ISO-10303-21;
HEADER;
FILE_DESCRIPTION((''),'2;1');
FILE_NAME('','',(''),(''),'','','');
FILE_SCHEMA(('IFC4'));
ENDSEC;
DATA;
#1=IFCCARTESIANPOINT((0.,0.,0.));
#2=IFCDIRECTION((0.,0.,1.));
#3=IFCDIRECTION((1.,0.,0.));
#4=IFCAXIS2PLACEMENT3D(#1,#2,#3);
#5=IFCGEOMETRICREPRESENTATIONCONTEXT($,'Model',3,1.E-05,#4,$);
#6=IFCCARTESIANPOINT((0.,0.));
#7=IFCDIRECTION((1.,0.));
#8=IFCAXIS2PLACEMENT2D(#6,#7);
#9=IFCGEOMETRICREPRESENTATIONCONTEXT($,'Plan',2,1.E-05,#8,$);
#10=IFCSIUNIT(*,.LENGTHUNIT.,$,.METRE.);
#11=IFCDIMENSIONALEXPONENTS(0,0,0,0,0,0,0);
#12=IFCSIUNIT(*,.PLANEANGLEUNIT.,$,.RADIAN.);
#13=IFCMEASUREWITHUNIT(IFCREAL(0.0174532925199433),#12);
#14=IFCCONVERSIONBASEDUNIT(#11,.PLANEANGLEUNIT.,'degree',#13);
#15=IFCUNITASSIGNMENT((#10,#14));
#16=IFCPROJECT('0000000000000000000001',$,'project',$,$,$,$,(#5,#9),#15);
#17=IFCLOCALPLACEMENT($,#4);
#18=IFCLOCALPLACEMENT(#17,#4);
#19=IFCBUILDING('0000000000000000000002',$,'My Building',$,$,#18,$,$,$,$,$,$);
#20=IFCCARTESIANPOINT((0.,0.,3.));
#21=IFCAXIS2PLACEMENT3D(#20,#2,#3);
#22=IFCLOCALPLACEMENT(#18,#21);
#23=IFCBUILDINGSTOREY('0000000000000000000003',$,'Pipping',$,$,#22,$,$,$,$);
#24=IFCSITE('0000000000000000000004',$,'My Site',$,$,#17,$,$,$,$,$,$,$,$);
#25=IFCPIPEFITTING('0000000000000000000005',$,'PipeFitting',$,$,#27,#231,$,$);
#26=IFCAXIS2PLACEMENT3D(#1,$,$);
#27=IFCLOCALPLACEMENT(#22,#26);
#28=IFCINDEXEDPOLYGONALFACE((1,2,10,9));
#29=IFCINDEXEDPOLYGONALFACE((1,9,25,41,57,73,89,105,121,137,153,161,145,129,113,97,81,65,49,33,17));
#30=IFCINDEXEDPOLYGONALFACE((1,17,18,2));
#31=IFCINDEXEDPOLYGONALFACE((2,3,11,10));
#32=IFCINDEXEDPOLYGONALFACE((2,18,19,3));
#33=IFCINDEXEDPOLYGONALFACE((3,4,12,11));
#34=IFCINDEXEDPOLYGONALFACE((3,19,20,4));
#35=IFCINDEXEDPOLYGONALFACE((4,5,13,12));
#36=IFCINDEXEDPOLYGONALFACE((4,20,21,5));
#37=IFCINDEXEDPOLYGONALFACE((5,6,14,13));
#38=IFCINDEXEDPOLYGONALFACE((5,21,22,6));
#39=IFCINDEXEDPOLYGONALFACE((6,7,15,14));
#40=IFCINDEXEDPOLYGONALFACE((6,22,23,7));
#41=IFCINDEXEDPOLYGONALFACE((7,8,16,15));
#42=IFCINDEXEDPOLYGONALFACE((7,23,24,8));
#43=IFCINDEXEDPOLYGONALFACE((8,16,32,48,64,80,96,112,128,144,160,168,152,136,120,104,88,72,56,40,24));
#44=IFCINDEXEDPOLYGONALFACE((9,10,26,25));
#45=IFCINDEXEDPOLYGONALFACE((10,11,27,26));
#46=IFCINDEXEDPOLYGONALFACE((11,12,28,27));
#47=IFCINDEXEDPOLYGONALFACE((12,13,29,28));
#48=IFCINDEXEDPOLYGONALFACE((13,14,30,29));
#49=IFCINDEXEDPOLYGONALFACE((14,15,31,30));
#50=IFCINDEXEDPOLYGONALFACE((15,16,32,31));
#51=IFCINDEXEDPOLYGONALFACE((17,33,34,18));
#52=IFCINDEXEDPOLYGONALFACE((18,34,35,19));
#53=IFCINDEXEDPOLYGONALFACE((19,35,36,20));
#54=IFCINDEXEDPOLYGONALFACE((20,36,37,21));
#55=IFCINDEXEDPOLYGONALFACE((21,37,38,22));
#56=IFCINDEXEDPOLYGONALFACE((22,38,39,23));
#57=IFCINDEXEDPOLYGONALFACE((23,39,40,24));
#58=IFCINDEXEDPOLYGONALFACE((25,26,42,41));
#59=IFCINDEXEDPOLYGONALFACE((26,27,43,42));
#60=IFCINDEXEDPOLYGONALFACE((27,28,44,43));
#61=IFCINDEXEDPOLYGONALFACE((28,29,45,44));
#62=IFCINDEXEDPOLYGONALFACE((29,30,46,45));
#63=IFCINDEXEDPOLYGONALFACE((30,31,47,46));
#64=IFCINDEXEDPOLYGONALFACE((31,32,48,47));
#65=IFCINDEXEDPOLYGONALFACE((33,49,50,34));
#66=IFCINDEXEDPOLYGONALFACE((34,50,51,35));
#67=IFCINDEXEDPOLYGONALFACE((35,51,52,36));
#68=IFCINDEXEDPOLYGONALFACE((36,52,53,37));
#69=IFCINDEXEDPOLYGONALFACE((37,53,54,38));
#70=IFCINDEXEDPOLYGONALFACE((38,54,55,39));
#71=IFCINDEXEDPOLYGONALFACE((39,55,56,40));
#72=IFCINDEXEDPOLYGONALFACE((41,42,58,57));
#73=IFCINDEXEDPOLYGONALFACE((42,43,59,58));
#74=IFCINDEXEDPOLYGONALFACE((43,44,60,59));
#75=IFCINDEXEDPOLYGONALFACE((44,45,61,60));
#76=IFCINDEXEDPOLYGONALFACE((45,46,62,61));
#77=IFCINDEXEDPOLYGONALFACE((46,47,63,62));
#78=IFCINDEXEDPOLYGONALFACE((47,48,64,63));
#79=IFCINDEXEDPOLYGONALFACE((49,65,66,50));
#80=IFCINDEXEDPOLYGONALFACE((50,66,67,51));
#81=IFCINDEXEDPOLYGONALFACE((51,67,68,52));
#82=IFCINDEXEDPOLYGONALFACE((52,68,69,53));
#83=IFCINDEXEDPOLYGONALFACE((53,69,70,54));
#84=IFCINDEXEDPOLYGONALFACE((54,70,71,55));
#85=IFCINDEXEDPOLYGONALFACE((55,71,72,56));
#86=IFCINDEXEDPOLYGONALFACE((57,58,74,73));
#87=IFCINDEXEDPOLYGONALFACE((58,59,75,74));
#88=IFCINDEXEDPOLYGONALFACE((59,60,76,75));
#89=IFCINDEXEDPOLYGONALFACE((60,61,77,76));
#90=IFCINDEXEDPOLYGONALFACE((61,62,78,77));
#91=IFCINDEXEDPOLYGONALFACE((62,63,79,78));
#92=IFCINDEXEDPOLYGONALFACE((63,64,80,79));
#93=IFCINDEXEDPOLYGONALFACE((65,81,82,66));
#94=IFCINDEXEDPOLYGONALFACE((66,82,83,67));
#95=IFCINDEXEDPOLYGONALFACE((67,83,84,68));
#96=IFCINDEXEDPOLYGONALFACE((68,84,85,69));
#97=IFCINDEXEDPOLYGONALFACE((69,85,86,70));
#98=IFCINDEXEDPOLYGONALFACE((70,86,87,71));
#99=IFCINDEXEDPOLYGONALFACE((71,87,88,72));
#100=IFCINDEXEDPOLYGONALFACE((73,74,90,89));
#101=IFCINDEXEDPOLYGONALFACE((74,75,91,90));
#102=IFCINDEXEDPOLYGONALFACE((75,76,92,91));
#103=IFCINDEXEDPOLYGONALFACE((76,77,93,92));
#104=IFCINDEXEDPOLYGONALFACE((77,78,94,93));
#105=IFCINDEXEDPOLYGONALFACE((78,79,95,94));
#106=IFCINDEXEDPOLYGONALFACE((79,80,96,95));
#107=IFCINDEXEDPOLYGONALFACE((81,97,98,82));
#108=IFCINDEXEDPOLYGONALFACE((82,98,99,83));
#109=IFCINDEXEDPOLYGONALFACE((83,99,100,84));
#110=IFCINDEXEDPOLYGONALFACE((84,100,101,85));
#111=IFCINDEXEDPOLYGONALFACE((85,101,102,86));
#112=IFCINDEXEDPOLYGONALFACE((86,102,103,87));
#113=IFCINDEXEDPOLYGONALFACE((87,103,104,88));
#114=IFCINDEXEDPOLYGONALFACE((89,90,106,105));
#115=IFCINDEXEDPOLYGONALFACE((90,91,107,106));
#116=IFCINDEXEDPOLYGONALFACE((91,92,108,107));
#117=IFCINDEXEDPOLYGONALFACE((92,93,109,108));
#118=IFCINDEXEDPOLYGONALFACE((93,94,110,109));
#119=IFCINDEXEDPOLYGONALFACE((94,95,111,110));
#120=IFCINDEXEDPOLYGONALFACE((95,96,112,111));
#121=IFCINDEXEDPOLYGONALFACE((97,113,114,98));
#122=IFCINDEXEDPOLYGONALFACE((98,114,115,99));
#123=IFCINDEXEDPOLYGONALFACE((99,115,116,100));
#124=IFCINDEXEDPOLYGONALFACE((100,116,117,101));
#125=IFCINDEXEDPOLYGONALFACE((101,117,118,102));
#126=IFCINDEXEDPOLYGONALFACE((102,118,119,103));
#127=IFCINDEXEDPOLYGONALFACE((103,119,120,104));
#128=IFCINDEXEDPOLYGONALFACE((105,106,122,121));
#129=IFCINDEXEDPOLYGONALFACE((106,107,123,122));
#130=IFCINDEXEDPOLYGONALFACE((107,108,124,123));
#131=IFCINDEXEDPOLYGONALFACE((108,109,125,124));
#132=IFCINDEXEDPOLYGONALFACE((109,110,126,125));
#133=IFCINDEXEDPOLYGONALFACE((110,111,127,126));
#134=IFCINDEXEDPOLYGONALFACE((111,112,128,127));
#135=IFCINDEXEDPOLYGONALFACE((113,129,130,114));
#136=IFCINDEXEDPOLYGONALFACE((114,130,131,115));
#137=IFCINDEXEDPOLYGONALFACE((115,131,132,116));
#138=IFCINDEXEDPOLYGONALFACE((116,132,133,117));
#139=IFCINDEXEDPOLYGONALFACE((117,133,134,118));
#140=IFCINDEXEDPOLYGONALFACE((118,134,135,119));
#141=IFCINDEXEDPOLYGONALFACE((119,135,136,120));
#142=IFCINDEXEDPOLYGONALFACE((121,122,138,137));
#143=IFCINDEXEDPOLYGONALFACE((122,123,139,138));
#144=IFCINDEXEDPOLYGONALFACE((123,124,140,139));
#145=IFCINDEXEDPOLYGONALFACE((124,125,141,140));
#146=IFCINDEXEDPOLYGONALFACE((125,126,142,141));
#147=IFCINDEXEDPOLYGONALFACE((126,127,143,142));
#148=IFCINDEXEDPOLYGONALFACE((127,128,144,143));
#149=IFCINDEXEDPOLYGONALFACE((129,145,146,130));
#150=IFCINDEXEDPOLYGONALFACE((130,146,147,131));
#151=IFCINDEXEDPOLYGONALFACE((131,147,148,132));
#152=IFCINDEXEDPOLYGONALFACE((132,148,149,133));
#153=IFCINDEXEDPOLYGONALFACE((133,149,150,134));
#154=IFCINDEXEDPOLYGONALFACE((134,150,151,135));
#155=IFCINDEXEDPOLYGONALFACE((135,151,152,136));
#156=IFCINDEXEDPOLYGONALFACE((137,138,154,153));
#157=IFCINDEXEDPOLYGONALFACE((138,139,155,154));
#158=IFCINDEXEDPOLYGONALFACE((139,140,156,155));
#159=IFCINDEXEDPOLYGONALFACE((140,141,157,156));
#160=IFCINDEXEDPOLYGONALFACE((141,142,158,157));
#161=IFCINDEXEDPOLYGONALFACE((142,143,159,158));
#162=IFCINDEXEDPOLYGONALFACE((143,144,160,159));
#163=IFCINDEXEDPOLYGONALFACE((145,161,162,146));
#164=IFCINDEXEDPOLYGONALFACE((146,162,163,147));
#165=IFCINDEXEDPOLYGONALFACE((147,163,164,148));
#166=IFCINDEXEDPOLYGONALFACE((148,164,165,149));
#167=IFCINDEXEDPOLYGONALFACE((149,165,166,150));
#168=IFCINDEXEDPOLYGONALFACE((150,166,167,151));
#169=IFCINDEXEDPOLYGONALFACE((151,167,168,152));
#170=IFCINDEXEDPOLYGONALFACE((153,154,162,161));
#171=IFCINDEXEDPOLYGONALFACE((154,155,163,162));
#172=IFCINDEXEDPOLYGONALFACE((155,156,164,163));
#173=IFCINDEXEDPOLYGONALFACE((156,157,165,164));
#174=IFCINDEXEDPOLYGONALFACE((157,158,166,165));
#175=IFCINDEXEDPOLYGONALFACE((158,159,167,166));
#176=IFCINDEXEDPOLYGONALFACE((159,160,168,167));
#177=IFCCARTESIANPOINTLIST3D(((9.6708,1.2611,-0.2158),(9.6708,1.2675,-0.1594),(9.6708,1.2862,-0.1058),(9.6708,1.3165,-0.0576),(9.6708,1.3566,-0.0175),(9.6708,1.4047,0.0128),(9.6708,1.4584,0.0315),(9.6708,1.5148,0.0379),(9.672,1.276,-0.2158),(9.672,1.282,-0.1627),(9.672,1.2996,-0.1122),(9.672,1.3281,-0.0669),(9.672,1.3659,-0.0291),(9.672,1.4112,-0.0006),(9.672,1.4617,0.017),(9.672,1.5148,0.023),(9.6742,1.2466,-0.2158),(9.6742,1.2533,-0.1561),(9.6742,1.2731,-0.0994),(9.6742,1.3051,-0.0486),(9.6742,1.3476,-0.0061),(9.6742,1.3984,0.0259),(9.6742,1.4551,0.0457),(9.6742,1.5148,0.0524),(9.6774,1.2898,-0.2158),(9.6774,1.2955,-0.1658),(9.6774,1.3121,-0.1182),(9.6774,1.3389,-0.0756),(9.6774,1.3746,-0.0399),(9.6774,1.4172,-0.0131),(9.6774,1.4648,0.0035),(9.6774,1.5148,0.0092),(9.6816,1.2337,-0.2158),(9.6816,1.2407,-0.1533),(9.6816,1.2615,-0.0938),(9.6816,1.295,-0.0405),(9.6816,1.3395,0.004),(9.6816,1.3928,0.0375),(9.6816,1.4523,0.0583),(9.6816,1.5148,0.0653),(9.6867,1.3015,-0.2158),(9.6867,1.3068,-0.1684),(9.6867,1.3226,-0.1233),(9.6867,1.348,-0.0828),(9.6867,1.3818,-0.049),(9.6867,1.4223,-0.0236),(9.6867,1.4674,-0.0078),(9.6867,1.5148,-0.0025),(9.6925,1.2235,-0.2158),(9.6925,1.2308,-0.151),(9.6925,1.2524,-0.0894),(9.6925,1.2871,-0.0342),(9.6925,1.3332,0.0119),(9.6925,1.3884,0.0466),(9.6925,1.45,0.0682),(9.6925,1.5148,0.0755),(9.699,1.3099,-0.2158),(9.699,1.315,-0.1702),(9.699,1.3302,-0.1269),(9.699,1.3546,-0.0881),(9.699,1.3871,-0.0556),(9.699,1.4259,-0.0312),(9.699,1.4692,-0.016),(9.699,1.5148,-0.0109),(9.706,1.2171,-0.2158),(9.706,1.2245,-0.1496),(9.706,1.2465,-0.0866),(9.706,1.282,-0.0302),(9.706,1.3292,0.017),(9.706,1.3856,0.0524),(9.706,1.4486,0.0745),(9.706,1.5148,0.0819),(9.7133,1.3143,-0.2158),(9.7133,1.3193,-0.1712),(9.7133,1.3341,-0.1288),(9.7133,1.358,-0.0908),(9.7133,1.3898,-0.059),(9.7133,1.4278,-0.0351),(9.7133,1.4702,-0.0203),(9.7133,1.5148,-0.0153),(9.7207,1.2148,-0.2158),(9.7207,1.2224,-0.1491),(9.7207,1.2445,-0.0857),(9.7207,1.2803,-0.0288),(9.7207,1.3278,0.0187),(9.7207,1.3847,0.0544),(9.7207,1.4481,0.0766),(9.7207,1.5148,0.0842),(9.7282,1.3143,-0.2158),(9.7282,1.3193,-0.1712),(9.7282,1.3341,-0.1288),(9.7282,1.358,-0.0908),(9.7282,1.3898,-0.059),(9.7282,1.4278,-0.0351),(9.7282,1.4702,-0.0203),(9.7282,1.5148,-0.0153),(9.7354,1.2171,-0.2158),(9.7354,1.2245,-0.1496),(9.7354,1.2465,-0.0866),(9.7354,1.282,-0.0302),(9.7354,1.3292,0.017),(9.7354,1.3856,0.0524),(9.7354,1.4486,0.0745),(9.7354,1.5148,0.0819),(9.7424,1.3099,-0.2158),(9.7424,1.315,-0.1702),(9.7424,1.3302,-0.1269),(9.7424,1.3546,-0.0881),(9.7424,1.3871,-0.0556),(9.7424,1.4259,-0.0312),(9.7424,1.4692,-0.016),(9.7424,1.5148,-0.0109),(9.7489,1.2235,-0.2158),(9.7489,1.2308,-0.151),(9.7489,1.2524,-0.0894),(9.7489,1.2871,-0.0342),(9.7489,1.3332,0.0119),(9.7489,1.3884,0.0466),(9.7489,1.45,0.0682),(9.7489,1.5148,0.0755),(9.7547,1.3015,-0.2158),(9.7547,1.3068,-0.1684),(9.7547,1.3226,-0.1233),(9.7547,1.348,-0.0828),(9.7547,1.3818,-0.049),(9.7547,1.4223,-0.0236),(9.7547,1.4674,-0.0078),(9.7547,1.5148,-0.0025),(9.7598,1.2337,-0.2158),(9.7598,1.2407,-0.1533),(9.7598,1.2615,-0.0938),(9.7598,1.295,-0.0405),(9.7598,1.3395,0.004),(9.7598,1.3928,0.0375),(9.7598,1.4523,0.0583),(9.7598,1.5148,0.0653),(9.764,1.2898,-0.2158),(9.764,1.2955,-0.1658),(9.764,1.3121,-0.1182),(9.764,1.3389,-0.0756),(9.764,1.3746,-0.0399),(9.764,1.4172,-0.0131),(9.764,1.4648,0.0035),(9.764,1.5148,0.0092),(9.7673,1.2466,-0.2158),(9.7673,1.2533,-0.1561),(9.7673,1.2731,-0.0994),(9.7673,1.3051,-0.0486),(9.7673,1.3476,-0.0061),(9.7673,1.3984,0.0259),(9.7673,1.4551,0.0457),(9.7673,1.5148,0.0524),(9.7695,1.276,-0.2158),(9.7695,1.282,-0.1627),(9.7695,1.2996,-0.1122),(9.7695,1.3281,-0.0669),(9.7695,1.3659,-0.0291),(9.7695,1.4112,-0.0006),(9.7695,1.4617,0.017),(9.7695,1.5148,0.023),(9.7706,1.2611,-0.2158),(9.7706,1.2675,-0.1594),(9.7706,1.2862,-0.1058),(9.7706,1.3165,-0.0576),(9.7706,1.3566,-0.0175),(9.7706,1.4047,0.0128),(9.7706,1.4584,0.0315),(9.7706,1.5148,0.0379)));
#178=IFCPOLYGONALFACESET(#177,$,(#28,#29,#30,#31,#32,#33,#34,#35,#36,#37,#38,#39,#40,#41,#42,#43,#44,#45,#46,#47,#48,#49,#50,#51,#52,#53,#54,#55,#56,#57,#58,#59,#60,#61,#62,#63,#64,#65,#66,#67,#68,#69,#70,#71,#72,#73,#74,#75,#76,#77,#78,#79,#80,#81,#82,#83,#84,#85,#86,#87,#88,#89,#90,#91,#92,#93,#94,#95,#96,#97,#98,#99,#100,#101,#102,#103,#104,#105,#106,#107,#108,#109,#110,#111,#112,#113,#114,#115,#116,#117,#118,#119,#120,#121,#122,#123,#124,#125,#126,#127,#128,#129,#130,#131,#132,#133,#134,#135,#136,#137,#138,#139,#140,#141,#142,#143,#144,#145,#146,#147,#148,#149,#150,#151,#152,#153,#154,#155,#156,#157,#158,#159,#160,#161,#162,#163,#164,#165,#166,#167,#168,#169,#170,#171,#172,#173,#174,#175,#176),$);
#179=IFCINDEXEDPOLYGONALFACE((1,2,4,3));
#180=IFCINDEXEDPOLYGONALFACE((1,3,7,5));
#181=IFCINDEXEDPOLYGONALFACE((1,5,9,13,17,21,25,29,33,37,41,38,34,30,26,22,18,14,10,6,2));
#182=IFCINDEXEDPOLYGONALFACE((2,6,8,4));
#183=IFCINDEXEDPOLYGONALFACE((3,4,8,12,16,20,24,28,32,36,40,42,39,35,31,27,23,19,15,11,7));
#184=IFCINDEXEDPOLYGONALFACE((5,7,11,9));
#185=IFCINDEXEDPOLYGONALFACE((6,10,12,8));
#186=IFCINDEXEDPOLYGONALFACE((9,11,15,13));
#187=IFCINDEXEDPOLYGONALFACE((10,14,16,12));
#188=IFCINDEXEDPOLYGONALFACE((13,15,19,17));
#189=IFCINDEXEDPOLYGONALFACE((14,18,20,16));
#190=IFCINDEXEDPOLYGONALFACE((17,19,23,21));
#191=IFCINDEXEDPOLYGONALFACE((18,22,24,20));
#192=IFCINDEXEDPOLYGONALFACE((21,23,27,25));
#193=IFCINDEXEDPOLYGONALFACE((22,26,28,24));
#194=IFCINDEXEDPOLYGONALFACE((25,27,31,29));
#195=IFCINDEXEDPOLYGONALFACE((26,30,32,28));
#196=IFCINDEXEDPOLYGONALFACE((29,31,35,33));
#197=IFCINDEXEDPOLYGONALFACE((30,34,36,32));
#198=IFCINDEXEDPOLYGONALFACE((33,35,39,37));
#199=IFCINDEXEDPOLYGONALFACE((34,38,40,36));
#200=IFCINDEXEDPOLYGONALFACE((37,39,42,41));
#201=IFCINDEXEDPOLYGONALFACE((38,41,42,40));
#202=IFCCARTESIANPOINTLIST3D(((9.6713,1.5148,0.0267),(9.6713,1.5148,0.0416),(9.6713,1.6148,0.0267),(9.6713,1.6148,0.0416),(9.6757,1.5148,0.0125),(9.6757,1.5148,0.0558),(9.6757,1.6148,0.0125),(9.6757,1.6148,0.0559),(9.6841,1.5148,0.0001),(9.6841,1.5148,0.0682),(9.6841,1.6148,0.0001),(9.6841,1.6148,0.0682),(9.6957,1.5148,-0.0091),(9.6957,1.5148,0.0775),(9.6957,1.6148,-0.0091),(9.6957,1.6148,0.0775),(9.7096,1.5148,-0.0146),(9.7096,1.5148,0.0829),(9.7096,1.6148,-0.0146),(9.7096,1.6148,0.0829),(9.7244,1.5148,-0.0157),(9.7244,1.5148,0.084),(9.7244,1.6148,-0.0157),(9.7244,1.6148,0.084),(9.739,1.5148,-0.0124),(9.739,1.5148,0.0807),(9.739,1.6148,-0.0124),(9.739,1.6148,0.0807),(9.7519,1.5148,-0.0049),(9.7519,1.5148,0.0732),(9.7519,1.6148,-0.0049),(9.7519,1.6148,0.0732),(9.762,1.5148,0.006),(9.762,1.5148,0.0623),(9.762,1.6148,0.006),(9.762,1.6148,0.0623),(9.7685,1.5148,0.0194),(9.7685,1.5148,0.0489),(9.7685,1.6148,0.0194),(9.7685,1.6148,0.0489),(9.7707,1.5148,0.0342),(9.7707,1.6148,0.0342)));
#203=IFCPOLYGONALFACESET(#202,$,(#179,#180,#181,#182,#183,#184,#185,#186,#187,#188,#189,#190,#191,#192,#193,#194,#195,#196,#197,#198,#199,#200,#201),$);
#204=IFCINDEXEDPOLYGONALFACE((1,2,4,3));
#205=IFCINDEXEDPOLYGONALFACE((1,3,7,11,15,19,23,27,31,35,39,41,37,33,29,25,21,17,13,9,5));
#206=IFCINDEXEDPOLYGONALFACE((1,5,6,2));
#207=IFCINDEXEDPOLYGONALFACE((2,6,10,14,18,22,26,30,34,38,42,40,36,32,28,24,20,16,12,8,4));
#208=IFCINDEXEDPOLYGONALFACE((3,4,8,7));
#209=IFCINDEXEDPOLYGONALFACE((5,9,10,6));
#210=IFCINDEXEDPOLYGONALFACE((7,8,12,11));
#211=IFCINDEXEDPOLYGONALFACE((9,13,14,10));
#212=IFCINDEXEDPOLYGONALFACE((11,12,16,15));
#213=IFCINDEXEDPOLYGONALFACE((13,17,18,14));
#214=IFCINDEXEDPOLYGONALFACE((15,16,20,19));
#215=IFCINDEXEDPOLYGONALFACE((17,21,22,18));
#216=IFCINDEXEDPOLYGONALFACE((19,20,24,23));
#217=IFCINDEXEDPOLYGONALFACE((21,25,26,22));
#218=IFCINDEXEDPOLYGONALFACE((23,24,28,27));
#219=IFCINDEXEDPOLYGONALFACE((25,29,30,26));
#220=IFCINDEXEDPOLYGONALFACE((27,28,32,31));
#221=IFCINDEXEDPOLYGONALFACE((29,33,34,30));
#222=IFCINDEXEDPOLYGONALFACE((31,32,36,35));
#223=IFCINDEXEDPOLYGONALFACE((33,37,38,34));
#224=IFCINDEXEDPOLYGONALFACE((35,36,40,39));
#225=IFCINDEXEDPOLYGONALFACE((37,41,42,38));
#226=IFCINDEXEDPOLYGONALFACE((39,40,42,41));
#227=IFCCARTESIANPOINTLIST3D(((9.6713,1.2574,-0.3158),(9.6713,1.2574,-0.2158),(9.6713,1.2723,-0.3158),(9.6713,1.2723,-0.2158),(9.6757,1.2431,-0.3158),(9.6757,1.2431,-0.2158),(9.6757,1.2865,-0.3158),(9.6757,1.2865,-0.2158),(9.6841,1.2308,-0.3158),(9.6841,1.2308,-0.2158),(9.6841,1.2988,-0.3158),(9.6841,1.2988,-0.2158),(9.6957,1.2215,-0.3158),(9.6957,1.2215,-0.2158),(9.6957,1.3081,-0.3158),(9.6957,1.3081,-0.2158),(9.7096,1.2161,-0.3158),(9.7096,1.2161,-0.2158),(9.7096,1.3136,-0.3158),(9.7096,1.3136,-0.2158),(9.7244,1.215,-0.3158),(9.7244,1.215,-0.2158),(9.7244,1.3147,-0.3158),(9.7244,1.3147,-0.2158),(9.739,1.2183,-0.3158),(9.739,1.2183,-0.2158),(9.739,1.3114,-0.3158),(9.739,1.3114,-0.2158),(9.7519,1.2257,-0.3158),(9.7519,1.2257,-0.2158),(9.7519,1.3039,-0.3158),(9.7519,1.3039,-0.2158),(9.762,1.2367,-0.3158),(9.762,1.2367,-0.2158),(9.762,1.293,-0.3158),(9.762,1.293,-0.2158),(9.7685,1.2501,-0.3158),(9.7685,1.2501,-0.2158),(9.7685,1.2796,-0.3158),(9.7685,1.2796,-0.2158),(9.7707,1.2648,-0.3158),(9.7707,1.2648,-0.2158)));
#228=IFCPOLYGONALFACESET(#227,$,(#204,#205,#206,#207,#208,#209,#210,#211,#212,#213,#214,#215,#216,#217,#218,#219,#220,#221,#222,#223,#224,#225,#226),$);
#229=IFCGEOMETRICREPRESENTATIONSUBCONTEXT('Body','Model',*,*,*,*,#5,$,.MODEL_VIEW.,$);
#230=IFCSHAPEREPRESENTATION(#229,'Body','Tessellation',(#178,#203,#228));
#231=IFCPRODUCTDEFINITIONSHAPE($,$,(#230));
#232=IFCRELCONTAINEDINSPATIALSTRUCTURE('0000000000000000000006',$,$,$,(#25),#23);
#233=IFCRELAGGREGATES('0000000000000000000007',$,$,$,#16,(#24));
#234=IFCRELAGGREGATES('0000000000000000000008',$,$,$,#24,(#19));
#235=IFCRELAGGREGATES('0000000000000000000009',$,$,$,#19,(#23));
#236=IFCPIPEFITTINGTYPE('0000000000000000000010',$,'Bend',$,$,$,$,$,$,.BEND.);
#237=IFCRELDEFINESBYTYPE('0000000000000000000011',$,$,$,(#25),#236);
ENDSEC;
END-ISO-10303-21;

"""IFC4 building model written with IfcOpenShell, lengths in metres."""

from ifc_helpers import new_model, entity, si_unit, converted_unit, frame, origin_with_axes, origin_2d_with_axis, place, context, subcontext, project, spatial, circle, extrude, source, transform, mapped, type_object, type_shapes, element, save


model = new_model("IFC4")

# Units and contexts
model_context = context("Model", 3, precision=1e-05, world=origin_with_axes())
plan_context = context("Plan", 2, precision=1e-05, world=origin_2d_with_axis())
body_context = subcontext(model_context, "Body", "Model", "MODEL_VIEW")
ifc_project = project(units=[si_unit("LENGTHUNIT", "METRE"), converted_unit("PLANEANGLEUNIT", "degree", entity("IfcReal", 0.0174532925199433), si_unit("PLANEANGLEUNIT", "RADIAN"), dimensions=[0, 0, 0, 0, 0, 0, 0])], contexts=[model_context, plan_context])

# Site, building, storey
site_placement = place(None, origin_with_axes())
site = spatial("IfcSite", under=ifc_project, at=site_placement, Name="My Site")
building_placement = place(site_placement, origin_with_axes())
building = spatial("IfcBuilding", under=site, at=building_placement, Name="My Building")
storey_placement = place(building_placement, frame((0.0, 0.0, 3.0), z_axis=(0.0, 0.0, 1.0), x_axis=(1.0, 0.0, 0.0)))
storey = spatial("IfcBuildingStorey", under=building, at=storey_placement, Name="Pipping")

# Pipe fitting
pipe_fitting_type_1 = type_object("IfcPipeFittingType", Name="Bend", PredefinedType="BEND")
shared_shape_1 = source(origin_with_axes(), body_context, "Body", "SolidModel", [
    entity("IfcSweptDiskSolid", entity("IfcIndexedPolyCurve", entity("IfcCartesianPointList3D", [[0.0, 0.0, 0.1], [0.0, -0.0732, 0.2768], [0.0, -0.25, 0.35]]), [entity("IfcArcIndex", [1, 2, 3])]), 0.05),
    extrude(circle(Radius=0.05), origin_with_axes(), (0.0, 0.0, 1.0), 0.1),
    extrude(circle(Radius=0.05), frame((0.0, -0.25, 0.35), z_axis=(0.0, -1.0, 0.000004), x_axis=(1.0, 0.0, 0.0)), (0.0, 0.0, 1.0), 0.1),
])
type_shapes(pipe_fitting_type_1, [shared_shape_1])
for number, where, z_axis, x_axis, name in (
    (1, (9.7207, 1.6148, 0.0342), (0.0, -1.0, -0.000004), (1.0, 0.0, 0.0), "PipeFitting"),
):
    element("IfcPipeFitting", number, at=place(storey_placement, frame(where, z_axis=z_axis, x_axis=x_axis)), inside=storey, type_object=pipe_fitting_type_1, Name=name, context=body_context, shape_type="MappedRepresentation", body=[
        mapped(shared_shape_1, transform((0.0, 0.0, 0.0), x_axis=(1.0, 0.0, 0.0), y_axis=(0.0, 1.0, 0.0), z_axis=(0.0, 0.0, 1.0), scale=1.0)),
    ])

save(model, "model.ifc")
